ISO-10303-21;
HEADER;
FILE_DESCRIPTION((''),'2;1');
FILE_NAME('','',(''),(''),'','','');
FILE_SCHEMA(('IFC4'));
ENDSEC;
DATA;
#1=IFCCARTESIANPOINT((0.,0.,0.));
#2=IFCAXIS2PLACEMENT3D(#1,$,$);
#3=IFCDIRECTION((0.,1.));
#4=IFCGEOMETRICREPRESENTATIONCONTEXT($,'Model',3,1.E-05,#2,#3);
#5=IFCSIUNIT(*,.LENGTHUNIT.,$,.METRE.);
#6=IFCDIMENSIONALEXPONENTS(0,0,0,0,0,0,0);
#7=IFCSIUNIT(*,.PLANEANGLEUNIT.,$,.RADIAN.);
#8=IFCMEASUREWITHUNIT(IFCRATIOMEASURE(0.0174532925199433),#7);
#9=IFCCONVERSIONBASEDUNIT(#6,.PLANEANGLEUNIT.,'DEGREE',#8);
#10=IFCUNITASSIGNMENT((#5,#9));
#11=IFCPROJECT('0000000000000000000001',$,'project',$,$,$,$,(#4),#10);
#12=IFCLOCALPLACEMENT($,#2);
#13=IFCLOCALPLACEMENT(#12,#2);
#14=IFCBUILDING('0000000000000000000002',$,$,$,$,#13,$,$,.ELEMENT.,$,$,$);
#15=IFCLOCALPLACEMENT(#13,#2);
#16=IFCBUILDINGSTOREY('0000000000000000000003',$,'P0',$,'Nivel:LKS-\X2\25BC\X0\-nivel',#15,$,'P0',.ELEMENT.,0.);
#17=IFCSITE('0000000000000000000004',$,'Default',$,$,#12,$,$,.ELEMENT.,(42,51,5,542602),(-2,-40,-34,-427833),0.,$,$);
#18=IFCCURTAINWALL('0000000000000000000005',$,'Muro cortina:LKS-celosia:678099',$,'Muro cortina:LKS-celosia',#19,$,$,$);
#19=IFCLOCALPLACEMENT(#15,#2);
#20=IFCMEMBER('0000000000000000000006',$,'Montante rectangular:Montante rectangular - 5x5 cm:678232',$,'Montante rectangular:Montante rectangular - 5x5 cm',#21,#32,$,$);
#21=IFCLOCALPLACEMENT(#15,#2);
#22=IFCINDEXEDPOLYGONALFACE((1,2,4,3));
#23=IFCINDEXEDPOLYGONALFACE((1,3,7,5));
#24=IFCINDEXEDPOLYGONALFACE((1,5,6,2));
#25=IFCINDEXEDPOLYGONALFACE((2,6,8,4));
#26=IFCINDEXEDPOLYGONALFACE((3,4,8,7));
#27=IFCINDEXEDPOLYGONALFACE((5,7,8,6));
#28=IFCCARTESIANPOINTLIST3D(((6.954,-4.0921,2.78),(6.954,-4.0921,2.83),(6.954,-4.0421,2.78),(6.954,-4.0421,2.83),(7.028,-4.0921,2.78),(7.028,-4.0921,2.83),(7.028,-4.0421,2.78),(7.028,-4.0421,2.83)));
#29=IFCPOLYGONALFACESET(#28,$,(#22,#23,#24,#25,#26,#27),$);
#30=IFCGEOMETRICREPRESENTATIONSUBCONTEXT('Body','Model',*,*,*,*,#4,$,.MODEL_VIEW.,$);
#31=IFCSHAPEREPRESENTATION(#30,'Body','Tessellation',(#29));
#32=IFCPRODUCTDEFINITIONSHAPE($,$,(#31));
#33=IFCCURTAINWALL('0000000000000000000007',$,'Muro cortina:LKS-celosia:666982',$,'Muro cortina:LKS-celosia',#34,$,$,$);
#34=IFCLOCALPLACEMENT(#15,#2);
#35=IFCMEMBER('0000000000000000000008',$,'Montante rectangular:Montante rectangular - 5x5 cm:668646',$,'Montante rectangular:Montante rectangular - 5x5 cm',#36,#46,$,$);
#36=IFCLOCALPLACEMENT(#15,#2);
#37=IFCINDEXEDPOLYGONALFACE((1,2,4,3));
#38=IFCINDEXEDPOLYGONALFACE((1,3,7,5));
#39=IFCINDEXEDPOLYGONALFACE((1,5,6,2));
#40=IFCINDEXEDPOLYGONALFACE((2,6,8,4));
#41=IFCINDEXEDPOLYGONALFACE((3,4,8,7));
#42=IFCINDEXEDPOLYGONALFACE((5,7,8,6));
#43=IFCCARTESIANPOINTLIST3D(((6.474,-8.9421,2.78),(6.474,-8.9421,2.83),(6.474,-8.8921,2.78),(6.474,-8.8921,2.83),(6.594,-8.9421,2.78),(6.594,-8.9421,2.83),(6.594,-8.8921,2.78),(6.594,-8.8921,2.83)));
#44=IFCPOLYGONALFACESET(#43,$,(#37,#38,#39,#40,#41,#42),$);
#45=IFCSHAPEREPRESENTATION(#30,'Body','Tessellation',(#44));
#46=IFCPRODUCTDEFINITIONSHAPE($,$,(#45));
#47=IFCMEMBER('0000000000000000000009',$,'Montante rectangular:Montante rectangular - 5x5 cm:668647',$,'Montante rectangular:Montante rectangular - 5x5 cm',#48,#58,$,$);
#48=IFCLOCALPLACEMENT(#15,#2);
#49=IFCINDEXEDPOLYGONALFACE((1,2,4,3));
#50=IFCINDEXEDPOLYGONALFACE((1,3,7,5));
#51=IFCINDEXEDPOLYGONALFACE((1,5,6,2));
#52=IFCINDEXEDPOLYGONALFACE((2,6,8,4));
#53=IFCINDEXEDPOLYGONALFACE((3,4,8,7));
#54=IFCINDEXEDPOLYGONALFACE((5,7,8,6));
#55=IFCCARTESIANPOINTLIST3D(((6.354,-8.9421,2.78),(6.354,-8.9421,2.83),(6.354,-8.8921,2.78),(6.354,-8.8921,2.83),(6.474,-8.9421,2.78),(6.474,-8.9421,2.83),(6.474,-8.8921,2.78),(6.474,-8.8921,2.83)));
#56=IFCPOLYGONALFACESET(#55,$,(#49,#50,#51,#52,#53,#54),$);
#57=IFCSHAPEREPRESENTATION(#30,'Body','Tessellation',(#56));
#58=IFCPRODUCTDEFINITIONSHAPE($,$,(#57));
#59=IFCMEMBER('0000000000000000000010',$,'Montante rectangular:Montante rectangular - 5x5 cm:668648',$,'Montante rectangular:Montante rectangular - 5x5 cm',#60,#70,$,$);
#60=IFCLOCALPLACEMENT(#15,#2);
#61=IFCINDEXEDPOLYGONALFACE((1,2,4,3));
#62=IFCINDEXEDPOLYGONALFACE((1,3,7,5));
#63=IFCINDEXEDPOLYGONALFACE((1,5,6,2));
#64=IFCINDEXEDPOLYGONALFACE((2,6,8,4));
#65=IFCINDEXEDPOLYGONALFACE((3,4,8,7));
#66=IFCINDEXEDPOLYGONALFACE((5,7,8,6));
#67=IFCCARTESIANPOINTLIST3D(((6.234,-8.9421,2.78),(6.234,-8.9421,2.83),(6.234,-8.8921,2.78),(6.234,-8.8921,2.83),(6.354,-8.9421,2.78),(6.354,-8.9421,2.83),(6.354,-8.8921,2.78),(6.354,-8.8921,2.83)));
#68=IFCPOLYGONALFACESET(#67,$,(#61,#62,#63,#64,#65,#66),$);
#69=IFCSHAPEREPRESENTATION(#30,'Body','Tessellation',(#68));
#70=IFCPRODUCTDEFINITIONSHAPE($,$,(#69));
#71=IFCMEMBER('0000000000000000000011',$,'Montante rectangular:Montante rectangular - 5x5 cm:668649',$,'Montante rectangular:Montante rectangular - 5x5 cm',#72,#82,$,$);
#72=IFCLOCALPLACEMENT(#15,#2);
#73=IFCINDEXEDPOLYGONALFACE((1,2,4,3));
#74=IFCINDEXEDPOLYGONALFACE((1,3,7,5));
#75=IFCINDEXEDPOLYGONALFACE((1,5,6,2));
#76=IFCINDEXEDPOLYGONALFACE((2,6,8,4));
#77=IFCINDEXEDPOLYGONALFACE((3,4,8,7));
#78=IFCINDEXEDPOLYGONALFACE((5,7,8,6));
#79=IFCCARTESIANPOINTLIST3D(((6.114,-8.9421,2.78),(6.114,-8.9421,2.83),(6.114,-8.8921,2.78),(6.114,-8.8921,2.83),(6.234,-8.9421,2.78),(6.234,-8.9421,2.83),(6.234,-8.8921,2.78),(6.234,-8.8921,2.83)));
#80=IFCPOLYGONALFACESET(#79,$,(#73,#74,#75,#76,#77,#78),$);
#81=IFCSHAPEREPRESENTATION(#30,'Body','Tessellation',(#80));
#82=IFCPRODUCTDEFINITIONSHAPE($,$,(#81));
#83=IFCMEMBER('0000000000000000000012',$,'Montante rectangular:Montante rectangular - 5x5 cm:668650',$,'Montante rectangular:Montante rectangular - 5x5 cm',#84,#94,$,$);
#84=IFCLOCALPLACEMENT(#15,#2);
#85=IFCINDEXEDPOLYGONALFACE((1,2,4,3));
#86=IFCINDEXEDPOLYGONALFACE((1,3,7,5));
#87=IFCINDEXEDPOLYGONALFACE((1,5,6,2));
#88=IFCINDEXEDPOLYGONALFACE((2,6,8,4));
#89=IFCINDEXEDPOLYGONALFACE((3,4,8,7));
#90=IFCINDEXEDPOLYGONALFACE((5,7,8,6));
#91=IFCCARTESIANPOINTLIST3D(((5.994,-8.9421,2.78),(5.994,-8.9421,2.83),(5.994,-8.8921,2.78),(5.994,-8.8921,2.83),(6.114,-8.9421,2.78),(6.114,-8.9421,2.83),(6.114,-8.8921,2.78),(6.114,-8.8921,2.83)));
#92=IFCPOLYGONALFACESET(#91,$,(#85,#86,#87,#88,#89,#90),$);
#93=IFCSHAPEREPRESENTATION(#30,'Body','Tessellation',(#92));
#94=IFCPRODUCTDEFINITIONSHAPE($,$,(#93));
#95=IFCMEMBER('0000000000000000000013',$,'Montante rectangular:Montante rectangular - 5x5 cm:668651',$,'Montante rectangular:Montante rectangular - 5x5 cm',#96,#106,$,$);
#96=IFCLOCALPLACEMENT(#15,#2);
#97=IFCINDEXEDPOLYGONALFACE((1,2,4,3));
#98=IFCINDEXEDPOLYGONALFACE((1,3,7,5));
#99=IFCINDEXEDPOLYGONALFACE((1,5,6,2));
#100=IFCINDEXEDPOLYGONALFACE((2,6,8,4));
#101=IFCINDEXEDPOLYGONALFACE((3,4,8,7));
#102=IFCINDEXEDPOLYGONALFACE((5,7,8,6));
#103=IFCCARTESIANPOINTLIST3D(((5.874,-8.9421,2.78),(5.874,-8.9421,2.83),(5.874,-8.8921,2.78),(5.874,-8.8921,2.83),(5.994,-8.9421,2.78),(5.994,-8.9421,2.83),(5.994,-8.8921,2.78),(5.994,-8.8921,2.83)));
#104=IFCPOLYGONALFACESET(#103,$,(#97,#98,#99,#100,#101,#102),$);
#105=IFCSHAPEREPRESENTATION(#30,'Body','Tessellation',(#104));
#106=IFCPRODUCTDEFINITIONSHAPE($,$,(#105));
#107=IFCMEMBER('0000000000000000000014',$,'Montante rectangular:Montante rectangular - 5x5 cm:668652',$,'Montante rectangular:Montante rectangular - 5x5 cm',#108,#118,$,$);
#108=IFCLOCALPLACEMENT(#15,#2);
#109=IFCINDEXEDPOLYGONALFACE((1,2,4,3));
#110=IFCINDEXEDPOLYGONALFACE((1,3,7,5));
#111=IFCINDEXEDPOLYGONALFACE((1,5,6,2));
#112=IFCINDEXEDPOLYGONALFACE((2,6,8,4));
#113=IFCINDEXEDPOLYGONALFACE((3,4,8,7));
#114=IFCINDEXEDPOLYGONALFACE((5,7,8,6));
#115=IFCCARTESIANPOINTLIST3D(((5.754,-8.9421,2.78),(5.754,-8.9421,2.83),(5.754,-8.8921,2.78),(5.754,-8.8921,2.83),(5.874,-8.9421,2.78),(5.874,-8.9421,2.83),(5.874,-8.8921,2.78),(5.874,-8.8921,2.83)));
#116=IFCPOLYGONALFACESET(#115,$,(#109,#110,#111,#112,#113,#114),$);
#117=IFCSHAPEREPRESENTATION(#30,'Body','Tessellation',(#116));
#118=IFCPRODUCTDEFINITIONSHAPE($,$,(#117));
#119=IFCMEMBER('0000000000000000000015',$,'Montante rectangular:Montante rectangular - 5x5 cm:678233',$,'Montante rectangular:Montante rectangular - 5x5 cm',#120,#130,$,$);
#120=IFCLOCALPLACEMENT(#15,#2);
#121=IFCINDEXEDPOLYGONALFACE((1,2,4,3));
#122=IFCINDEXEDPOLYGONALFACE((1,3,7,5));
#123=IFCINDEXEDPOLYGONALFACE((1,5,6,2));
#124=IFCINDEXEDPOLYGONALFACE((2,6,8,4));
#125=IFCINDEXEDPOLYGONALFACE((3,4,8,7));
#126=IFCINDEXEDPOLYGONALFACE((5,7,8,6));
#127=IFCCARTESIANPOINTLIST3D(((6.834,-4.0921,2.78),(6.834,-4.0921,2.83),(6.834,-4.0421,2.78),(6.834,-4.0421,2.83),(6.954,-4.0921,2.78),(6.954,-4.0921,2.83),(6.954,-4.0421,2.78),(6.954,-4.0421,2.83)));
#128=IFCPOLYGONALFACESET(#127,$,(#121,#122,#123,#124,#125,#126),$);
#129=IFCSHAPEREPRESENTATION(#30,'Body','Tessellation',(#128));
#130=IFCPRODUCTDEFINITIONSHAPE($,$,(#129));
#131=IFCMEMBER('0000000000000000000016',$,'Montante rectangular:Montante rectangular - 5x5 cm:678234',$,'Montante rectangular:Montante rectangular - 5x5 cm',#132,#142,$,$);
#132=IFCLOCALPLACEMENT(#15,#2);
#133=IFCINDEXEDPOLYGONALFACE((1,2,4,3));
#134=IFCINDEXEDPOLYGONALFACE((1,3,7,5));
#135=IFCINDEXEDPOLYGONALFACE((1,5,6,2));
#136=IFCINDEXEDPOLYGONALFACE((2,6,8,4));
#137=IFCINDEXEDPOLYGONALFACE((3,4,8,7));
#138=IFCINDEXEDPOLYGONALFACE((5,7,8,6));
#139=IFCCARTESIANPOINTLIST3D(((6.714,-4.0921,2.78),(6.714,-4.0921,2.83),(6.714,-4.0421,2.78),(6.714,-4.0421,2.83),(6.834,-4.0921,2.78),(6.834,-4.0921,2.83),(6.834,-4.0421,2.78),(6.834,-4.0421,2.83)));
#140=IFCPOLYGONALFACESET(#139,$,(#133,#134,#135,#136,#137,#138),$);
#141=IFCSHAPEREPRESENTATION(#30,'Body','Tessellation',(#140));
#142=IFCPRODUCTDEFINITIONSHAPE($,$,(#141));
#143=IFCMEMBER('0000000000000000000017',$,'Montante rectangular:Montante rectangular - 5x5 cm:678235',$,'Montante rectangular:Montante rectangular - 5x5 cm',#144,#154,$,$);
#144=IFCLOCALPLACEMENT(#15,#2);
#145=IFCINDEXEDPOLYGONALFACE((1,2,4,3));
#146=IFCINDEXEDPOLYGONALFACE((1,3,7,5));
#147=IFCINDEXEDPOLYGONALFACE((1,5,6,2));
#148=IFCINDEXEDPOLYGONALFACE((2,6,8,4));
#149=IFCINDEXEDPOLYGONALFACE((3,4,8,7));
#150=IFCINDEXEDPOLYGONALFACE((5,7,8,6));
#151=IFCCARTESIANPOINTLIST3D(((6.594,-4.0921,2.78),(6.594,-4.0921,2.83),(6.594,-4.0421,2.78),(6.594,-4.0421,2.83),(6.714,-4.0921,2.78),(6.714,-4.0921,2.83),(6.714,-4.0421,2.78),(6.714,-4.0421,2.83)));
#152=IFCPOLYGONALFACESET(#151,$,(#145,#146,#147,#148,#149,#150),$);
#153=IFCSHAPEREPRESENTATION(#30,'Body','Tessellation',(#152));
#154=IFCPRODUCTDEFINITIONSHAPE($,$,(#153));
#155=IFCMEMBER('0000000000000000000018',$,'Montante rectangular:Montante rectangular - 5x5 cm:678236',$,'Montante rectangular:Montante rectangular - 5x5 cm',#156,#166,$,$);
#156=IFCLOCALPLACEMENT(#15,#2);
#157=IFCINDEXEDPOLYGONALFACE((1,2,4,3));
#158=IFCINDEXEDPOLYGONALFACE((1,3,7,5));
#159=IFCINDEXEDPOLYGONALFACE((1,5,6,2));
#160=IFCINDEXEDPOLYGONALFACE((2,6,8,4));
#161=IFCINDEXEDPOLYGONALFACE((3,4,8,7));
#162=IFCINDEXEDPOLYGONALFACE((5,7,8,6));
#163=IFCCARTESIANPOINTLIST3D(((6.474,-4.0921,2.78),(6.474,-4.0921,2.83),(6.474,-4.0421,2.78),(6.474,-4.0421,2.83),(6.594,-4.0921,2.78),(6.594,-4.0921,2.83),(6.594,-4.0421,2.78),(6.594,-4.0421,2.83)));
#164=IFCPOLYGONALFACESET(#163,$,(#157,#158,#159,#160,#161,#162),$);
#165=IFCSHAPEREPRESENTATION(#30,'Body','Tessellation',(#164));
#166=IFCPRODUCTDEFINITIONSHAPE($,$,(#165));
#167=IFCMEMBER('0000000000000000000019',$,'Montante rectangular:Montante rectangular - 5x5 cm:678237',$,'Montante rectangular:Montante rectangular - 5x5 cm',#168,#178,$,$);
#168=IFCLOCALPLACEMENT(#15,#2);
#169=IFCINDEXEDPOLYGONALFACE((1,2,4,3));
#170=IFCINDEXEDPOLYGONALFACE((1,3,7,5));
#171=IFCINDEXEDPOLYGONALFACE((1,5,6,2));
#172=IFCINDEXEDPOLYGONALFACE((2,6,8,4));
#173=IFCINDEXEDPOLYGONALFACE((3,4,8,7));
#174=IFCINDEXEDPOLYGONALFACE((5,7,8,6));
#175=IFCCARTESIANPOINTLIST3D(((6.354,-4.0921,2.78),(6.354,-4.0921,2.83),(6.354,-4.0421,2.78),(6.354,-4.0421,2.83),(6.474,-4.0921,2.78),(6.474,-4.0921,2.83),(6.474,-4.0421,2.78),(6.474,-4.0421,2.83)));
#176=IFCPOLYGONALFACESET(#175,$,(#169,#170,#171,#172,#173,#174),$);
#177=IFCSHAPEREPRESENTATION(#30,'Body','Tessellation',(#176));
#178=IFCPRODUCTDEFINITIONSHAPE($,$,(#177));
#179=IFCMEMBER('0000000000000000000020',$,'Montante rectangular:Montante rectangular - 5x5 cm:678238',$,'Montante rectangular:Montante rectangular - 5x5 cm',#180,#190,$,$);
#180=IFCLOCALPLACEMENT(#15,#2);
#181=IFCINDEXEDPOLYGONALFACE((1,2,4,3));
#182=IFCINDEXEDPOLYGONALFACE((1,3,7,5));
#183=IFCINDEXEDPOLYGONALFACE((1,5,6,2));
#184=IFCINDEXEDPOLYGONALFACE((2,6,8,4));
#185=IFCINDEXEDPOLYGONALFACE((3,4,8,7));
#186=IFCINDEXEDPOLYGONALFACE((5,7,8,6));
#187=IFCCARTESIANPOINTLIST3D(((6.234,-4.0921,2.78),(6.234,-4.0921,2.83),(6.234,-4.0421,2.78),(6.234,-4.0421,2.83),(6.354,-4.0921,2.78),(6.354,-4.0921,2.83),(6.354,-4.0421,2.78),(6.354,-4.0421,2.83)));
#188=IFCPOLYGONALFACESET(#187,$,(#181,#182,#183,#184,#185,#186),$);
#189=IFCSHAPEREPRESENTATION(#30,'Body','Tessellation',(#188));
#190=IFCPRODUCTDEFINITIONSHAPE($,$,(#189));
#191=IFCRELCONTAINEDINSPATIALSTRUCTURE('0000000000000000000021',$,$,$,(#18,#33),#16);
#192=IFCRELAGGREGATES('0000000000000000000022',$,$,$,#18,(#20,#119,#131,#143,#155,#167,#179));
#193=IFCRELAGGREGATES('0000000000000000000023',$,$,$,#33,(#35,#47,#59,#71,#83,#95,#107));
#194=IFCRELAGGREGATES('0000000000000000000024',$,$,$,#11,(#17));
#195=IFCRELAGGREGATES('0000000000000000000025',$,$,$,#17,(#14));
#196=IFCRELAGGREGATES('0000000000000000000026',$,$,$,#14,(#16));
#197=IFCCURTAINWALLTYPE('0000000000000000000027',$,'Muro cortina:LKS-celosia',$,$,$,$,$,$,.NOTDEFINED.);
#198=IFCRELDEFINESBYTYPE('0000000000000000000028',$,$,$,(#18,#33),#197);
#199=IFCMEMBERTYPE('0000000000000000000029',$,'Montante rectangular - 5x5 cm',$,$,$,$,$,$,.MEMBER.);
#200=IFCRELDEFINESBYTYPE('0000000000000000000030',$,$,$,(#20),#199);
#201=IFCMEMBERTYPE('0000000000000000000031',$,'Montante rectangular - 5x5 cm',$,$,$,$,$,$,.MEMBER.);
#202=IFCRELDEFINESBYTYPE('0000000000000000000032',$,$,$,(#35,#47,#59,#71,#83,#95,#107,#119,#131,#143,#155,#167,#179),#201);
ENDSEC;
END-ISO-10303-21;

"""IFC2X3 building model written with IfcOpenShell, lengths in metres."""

from ifc_helpers import new_model, entity, si_unit, converted_unit, direction, frame, origin, origin_2d_with_axis, place, context, subcontext, project, spatial, rectangle, extrude, source, transform, mapped, type_object, type_shapes, element, aggregate, save


model = new_model("IFC2X3")

# Units and contexts
model_context = context("Model", 3, precision=1e-05, world=origin(), true_north=direction((0.0, 1.0)))
body_context = subcontext(model_context, "Body", "Model", "MODEL_VIEW")
ifc_project = project(units=[si_unit("LENGTHUNIT", "METRE"), converted_unit("PLANEANGLEUNIT", "DEGREE", entity("IfcRatioMeasure", 0.0174532925199433), si_unit("PLANEANGLEUNIT", "RADIAN"), dimensions=[0, 0, 0, 0, 0, 0, 0])], contexts=[model_context])

# Site, building, storey
site_placement = place(None, origin())
site = spatial("IfcSite", under=ifc_project, at=site_placement, Name="Default", CompositionType="ELEMENT", RefLatitude=(42, 51, 5, 542602), RefLongitude=(-2, -40, -34, -427833), RefElevation=0.0)
building_placement = place(site_placement, origin())
building = spatial("IfcBuilding", under=site, at=building_placement, CompositionType="ELEMENT")
storey_placement = place(building_placement, origin())
storey = spatial("IfcBuildingStorey", under=building, at=storey_placement, Name="P0", ObjectType="Nivel:LKS-▼-nivel", LongName="P0", CompositionType="ELEMENT", Elevation=0.0)

# Curtain wall, member
curtain_wall_type = type_object("IfcCurtainWallType", Name="Muro cortina:LKS-celosia", PredefinedType="NOTDEFINED")
curtain_wall_1_placement = place(storey_placement, origin())
curtain_wall_1 = element("IfcCurtainWall", 1, at=curtain_wall_1_placement, inside=storey, type_object=curtain_wall_type, Name="Muro cortina:LKS-celosia:678099", ObjectType="Muro cortina:LKS-celosia")
member_type_1 = type_object("IfcMemberType", Name="Montante rectangular - 5x5 cm", PredefinedType="MEMBER")
shared_shape_1 = source(origin(), body_context, "Body", "SweptSolid", [
    extrude(rectangle(XDim=0.05, YDim=0.05, at=origin_2d_with_axis()), frame((-0.025, -0.1, -0.074), z_axis=(0.0, 0.0, 1.0), x_axis=(0.0, -1.0, 0.0)), (0.0, 0.0, 1.0), 0.074),
])
type_shapes(member_type_1, [shared_shape_1])
member_1_placement = place(storey_placement, frame((6.954, -4.1671, 2.78), z_axis=(-1.0, 0.0, 0.0), x_axis=(0.0, 0.0, -1.0)))
member_1 = element("IfcMember", 2, at=member_1_placement, type_object=member_type_1, Name="Montante rectangular:Montante rectangular - 5x5 cm:678232", ObjectType="Montante rectangular:Montante rectangular - 5x5 cm", context=body_context, shape_type="MappedRepresentation", body=[
    mapped(shared_shape_1, transform((0.0, 0.0, 0.0), scale=1.0)),
])

# Curtain wall, members
curtain_wall_2_placement = place(storey_placement, origin())
curtain_wall_2 = element("IfcCurtainWall", 3, at=curtain_wall_2_placement, inside=storey, type_object=curtain_wall_type, Name="Muro cortina:LKS-celosia:666982", ObjectType="Muro cortina:LKS-celosia")
member_type_2 = type_object("IfcMemberType", Name="Montante rectangular - 5x5 cm", PredefinedType="MEMBER")
shared_shape_2 = source(origin(), body_context, "Body", "SweptSolid", [
    extrude(rectangle(XDim=0.05, YDim=0.05, at=origin_2d_with_axis()), frame((-0.025, -0.1, -0.12), z_axis=(0.0, 0.0, 1.0), x_axis=(0.0, -1.0, 0.0)), (0.0, 0.0, 1.0), 0.12),
])
type_shapes(member_type_2, [shared_shape_2])
member_2_placement = place(storey_placement, frame((6.474, -9.0171, 2.78), z_axis=(-1.0, 0.0, 0.0), x_axis=(0.0, 0.0, -1.0)))
member_2 = element("IfcMember", 4, at=member_2_placement, type_object=member_type_2, Name="Montante rectangular:Montante rectangular - 5x5 cm:668646", ObjectType="Montante rectangular:Montante rectangular - 5x5 cm", context=body_context, shape_type="MappedRepresentation", body=[
    mapped(shared_shape_2, transform((0.0, 0.0, 0.0), scale=1.0)),
])
member_3_placement = place(storey_placement, frame((6.354, -9.0171, 2.78), z_axis=(-1.0, 0.0, 0.0), x_axis=(0.0, 0.0, -1.0)))
member_3 = element("IfcMember", 5, at=member_3_placement, type_object=member_type_2, Name="Montante rectangular:Montante rectangular - 5x5 cm:668647", ObjectType="Montante rectangular:Montante rectangular - 5x5 cm", context=body_context, shape_type="MappedRepresentation", body=[
    mapped(shared_shape_2, transform((0.0, 0.0, 0.0), scale=1.0)),
])
member_4_placement = place(storey_placement, frame((6.234, -9.0171, 2.78), z_axis=(-1.0, 0.0, 0.0), x_axis=(0.0, 0.0, -1.0)))
member_4 = element("IfcMember", 6, at=member_4_placement, type_object=member_type_2, Name="Montante rectangular:Montante rectangular - 5x5 cm:668648", ObjectType="Montante rectangular:Montante rectangular - 5x5 cm", context=body_context, shape_type="MappedRepresentation", body=[
    mapped(shared_shape_2, transform((0.0, 0.0, 0.0), scale=1.0)),
])
member_5_placement = place(storey_placement, frame((6.114, -9.0171, 2.78), z_axis=(-1.0, 0.0, 0.0), x_axis=(0.0, 0.0, -1.0)))
member_5 = element("IfcMember", 7, at=member_5_placement, type_object=member_type_2, Name="Montante rectangular:Montante rectangular - 5x5 cm:668649", ObjectType="Montante rectangular:Montante rectangular - 5x5 cm", context=body_context, shape_type="MappedRepresentation", body=[
    mapped(shared_shape_2, transform((0.0, 0.0, 0.0), scale=1.0)),
])
member_6_placement = place(storey_placement, frame((5.994, -9.0171, 2.78), z_axis=(-1.0, 0.0, 0.0), x_axis=(0.0, 0.0, -1.0)))
member_6 = element("IfcMember", 8, at=member_6_placement, type_object=member_type_2, Name="Montante rectangular:Montante rectangular - 5x5 cm:668650", ObjectType="Montante rectangular:Montante rectangular - 5x5 cm", context=body_context, shape_type="MappedRepresentation", body=[
    mapped(shared_shape_2, transform((0.0, 0.0, 0.0), scale=1.0)),
])
member_7_placement = place(storey_placement, frame((5.874, -9.0171, 2.78), z_axis=(-1.0, 0.0, 0.0), x_axis=(0.0, 0.0, -1.0)))
member_7 = element("IfcMember", 9, at=member_7_placement, type_object=member_type_2, Name="Montante rectangular:Montante rectangular - 5x5 cm:668651", ObjectType="Montante rectangular:Montante rectangular - 5x5 cm", context=body_context, shape_type="MappedRepresentation", body=[
    mapped(shared_shape_2, transform((0.0, 0.0, 0.0), scale=1.0)),
])
member_8_placement = place(storey_placement, frame((5.754, -9.0171, 2.78), z_axis=(-1.0, 0.0, 0.0), x_axis=(0.0, 0.0, -1.0)))
member_8 = element("IfcMember", 10, at=member_8_placement, type_object=member_type_2, Name="Montante rectangular:Montante rectangular - 5x5 cm:668652", ObjectType="Montante rectangular:Montante rectangular - 5x5 cm", context=body_context, shape_type="MappedRepresentation", body=[
    mapped(shared_shape_2, transform((0.0, 0.0, 0.0), scale=1.0)),
])

# Members
member_9_placement = place(storey_placement, frame((6.834, -4.1671, 2.78), z_axis=(-1.0, 0.0, 0.0), x_axis=(0.0, 0.0, -1.0)))
member_9 = element("IfcMember", 11, at=member_9_placement, type_object=member_type_2, Name="Montante rectangular:Montante rectangular - 5x5 cm:678233", ObjectType="Montante rectangular:Montante rectangular - 5x5 cm", context=body_context, shape_type="MappedRepresentation", body=[
    mapped(shared_shape_2, transform((0.0, 0.0, 0.0), scale=1.0)),
])
member_10_placement = place(storey_placement, frame((6.714, -4.1671, 2.78), z_axis=(-1.0, 0.0, 0.0), x_axis=(0.0, 0.0, -1.0)))
member_10 = element("IfcMember", 12, at=member_10_placement, type_object=member_type_2, Name="Montante rectangular:Montante rectangular - 5x5 cm:678234", ObjectType="Montante rectangular:Montante rectangular - 5x5 cm", context=body_context, shape_type="MappedRepresentation", body=[
    mapped(shared_shape_2, transform((0.0, 0.0, 0.0), scale=1.0)),
])
member_11_placement = place(storey_placement, frame((6.594, -4.1671, 2.78), z_axis=(-1.0, 0.0, 0.0), x_axis=(0.0, 0.0, -1.0)))
member_11 = element("IfcMember", 13, at=member_11_placement, type_object=member_type_2, Name="Montante rectangular:Montante rectangular - 5x5 cm:678235", ObjectType="Montante rectangular:Montante rectangular - 5x5 cm", context=body_context, shape_type="MappedRepresentation", body=[
    mapped(shared_shape_2, transform((0.0, 0.0, 0.0), scale=1.0)),
])
member_12_placement = place(storey_placement, frame((6.474, -4.1671, 2.78), z_axis=(-1.0, 0.0, 0.0), x_axis=(0.0, 0.0, -1.0)))
member_12 = element("IfcMember", 14, at=member_12_placement, type_object=member_type_2, Name="Montante rectangular:Montante rectangular - 5x5 cm:678236", ObjectType="Montante rectangular:Montante rectangular - 5x5 cm", context=body_context, shape_type="MappedRepresentation", body=[
    mapped(shared_shape_2, transform((0.0, 0.0, 0.0), scale=1.0)),
])
member_13_placement = place(storey_placement, frame((6.354, -4.1671, 2.78), z_axis=(-1.0, 0.0, 0.0), x_axis=(0.0, 0.0, -1.0)))
member_13 = element("IfcMember", 15, at=member_13_placement, type_object=member_type_2, Name="Montante rectangular:Montante rectangular - 5x5 cm:678237", ObjectType="Montante rectangular:Montante rectangular - 5x5 cm", context=body_context, shape_type="MappedRepresentation", body=[
    mapped(shared_shape_2, transform((0.0, 0.0, 0.0), scale=1.0)),
])
member_14_placement = place(storey_placement, frame((6.234, -4.1671, 2.78), z_axis=(-1.0, 0.0, 0.0), x_axis=(0.0, 0.0, -1.0)))
member_14 = element("IfcMember", 16, at=member_14_placement, type_object=member_type_2, Name="Montante rectangular:Montante rectangular - 5x5 cm:678238", ObjectType="Montante rectangular:Montante rectangular - 5x5 cm", context=body_context, shape_type="MappedRepresentation", body=[
    mapped(shared_shape_2, transform((0.0, 0.0, 0.0), scale=1.0)),
])
aggregate(curtain_wall_1, [member_1, member_9, member_10, member_11, member_12, member_13, member_14])

aggregate(curtain_wall_2, [member_2, member_3, member_4, member_5, member_6, member_7, member_8])

save(model, "model.ifc")
